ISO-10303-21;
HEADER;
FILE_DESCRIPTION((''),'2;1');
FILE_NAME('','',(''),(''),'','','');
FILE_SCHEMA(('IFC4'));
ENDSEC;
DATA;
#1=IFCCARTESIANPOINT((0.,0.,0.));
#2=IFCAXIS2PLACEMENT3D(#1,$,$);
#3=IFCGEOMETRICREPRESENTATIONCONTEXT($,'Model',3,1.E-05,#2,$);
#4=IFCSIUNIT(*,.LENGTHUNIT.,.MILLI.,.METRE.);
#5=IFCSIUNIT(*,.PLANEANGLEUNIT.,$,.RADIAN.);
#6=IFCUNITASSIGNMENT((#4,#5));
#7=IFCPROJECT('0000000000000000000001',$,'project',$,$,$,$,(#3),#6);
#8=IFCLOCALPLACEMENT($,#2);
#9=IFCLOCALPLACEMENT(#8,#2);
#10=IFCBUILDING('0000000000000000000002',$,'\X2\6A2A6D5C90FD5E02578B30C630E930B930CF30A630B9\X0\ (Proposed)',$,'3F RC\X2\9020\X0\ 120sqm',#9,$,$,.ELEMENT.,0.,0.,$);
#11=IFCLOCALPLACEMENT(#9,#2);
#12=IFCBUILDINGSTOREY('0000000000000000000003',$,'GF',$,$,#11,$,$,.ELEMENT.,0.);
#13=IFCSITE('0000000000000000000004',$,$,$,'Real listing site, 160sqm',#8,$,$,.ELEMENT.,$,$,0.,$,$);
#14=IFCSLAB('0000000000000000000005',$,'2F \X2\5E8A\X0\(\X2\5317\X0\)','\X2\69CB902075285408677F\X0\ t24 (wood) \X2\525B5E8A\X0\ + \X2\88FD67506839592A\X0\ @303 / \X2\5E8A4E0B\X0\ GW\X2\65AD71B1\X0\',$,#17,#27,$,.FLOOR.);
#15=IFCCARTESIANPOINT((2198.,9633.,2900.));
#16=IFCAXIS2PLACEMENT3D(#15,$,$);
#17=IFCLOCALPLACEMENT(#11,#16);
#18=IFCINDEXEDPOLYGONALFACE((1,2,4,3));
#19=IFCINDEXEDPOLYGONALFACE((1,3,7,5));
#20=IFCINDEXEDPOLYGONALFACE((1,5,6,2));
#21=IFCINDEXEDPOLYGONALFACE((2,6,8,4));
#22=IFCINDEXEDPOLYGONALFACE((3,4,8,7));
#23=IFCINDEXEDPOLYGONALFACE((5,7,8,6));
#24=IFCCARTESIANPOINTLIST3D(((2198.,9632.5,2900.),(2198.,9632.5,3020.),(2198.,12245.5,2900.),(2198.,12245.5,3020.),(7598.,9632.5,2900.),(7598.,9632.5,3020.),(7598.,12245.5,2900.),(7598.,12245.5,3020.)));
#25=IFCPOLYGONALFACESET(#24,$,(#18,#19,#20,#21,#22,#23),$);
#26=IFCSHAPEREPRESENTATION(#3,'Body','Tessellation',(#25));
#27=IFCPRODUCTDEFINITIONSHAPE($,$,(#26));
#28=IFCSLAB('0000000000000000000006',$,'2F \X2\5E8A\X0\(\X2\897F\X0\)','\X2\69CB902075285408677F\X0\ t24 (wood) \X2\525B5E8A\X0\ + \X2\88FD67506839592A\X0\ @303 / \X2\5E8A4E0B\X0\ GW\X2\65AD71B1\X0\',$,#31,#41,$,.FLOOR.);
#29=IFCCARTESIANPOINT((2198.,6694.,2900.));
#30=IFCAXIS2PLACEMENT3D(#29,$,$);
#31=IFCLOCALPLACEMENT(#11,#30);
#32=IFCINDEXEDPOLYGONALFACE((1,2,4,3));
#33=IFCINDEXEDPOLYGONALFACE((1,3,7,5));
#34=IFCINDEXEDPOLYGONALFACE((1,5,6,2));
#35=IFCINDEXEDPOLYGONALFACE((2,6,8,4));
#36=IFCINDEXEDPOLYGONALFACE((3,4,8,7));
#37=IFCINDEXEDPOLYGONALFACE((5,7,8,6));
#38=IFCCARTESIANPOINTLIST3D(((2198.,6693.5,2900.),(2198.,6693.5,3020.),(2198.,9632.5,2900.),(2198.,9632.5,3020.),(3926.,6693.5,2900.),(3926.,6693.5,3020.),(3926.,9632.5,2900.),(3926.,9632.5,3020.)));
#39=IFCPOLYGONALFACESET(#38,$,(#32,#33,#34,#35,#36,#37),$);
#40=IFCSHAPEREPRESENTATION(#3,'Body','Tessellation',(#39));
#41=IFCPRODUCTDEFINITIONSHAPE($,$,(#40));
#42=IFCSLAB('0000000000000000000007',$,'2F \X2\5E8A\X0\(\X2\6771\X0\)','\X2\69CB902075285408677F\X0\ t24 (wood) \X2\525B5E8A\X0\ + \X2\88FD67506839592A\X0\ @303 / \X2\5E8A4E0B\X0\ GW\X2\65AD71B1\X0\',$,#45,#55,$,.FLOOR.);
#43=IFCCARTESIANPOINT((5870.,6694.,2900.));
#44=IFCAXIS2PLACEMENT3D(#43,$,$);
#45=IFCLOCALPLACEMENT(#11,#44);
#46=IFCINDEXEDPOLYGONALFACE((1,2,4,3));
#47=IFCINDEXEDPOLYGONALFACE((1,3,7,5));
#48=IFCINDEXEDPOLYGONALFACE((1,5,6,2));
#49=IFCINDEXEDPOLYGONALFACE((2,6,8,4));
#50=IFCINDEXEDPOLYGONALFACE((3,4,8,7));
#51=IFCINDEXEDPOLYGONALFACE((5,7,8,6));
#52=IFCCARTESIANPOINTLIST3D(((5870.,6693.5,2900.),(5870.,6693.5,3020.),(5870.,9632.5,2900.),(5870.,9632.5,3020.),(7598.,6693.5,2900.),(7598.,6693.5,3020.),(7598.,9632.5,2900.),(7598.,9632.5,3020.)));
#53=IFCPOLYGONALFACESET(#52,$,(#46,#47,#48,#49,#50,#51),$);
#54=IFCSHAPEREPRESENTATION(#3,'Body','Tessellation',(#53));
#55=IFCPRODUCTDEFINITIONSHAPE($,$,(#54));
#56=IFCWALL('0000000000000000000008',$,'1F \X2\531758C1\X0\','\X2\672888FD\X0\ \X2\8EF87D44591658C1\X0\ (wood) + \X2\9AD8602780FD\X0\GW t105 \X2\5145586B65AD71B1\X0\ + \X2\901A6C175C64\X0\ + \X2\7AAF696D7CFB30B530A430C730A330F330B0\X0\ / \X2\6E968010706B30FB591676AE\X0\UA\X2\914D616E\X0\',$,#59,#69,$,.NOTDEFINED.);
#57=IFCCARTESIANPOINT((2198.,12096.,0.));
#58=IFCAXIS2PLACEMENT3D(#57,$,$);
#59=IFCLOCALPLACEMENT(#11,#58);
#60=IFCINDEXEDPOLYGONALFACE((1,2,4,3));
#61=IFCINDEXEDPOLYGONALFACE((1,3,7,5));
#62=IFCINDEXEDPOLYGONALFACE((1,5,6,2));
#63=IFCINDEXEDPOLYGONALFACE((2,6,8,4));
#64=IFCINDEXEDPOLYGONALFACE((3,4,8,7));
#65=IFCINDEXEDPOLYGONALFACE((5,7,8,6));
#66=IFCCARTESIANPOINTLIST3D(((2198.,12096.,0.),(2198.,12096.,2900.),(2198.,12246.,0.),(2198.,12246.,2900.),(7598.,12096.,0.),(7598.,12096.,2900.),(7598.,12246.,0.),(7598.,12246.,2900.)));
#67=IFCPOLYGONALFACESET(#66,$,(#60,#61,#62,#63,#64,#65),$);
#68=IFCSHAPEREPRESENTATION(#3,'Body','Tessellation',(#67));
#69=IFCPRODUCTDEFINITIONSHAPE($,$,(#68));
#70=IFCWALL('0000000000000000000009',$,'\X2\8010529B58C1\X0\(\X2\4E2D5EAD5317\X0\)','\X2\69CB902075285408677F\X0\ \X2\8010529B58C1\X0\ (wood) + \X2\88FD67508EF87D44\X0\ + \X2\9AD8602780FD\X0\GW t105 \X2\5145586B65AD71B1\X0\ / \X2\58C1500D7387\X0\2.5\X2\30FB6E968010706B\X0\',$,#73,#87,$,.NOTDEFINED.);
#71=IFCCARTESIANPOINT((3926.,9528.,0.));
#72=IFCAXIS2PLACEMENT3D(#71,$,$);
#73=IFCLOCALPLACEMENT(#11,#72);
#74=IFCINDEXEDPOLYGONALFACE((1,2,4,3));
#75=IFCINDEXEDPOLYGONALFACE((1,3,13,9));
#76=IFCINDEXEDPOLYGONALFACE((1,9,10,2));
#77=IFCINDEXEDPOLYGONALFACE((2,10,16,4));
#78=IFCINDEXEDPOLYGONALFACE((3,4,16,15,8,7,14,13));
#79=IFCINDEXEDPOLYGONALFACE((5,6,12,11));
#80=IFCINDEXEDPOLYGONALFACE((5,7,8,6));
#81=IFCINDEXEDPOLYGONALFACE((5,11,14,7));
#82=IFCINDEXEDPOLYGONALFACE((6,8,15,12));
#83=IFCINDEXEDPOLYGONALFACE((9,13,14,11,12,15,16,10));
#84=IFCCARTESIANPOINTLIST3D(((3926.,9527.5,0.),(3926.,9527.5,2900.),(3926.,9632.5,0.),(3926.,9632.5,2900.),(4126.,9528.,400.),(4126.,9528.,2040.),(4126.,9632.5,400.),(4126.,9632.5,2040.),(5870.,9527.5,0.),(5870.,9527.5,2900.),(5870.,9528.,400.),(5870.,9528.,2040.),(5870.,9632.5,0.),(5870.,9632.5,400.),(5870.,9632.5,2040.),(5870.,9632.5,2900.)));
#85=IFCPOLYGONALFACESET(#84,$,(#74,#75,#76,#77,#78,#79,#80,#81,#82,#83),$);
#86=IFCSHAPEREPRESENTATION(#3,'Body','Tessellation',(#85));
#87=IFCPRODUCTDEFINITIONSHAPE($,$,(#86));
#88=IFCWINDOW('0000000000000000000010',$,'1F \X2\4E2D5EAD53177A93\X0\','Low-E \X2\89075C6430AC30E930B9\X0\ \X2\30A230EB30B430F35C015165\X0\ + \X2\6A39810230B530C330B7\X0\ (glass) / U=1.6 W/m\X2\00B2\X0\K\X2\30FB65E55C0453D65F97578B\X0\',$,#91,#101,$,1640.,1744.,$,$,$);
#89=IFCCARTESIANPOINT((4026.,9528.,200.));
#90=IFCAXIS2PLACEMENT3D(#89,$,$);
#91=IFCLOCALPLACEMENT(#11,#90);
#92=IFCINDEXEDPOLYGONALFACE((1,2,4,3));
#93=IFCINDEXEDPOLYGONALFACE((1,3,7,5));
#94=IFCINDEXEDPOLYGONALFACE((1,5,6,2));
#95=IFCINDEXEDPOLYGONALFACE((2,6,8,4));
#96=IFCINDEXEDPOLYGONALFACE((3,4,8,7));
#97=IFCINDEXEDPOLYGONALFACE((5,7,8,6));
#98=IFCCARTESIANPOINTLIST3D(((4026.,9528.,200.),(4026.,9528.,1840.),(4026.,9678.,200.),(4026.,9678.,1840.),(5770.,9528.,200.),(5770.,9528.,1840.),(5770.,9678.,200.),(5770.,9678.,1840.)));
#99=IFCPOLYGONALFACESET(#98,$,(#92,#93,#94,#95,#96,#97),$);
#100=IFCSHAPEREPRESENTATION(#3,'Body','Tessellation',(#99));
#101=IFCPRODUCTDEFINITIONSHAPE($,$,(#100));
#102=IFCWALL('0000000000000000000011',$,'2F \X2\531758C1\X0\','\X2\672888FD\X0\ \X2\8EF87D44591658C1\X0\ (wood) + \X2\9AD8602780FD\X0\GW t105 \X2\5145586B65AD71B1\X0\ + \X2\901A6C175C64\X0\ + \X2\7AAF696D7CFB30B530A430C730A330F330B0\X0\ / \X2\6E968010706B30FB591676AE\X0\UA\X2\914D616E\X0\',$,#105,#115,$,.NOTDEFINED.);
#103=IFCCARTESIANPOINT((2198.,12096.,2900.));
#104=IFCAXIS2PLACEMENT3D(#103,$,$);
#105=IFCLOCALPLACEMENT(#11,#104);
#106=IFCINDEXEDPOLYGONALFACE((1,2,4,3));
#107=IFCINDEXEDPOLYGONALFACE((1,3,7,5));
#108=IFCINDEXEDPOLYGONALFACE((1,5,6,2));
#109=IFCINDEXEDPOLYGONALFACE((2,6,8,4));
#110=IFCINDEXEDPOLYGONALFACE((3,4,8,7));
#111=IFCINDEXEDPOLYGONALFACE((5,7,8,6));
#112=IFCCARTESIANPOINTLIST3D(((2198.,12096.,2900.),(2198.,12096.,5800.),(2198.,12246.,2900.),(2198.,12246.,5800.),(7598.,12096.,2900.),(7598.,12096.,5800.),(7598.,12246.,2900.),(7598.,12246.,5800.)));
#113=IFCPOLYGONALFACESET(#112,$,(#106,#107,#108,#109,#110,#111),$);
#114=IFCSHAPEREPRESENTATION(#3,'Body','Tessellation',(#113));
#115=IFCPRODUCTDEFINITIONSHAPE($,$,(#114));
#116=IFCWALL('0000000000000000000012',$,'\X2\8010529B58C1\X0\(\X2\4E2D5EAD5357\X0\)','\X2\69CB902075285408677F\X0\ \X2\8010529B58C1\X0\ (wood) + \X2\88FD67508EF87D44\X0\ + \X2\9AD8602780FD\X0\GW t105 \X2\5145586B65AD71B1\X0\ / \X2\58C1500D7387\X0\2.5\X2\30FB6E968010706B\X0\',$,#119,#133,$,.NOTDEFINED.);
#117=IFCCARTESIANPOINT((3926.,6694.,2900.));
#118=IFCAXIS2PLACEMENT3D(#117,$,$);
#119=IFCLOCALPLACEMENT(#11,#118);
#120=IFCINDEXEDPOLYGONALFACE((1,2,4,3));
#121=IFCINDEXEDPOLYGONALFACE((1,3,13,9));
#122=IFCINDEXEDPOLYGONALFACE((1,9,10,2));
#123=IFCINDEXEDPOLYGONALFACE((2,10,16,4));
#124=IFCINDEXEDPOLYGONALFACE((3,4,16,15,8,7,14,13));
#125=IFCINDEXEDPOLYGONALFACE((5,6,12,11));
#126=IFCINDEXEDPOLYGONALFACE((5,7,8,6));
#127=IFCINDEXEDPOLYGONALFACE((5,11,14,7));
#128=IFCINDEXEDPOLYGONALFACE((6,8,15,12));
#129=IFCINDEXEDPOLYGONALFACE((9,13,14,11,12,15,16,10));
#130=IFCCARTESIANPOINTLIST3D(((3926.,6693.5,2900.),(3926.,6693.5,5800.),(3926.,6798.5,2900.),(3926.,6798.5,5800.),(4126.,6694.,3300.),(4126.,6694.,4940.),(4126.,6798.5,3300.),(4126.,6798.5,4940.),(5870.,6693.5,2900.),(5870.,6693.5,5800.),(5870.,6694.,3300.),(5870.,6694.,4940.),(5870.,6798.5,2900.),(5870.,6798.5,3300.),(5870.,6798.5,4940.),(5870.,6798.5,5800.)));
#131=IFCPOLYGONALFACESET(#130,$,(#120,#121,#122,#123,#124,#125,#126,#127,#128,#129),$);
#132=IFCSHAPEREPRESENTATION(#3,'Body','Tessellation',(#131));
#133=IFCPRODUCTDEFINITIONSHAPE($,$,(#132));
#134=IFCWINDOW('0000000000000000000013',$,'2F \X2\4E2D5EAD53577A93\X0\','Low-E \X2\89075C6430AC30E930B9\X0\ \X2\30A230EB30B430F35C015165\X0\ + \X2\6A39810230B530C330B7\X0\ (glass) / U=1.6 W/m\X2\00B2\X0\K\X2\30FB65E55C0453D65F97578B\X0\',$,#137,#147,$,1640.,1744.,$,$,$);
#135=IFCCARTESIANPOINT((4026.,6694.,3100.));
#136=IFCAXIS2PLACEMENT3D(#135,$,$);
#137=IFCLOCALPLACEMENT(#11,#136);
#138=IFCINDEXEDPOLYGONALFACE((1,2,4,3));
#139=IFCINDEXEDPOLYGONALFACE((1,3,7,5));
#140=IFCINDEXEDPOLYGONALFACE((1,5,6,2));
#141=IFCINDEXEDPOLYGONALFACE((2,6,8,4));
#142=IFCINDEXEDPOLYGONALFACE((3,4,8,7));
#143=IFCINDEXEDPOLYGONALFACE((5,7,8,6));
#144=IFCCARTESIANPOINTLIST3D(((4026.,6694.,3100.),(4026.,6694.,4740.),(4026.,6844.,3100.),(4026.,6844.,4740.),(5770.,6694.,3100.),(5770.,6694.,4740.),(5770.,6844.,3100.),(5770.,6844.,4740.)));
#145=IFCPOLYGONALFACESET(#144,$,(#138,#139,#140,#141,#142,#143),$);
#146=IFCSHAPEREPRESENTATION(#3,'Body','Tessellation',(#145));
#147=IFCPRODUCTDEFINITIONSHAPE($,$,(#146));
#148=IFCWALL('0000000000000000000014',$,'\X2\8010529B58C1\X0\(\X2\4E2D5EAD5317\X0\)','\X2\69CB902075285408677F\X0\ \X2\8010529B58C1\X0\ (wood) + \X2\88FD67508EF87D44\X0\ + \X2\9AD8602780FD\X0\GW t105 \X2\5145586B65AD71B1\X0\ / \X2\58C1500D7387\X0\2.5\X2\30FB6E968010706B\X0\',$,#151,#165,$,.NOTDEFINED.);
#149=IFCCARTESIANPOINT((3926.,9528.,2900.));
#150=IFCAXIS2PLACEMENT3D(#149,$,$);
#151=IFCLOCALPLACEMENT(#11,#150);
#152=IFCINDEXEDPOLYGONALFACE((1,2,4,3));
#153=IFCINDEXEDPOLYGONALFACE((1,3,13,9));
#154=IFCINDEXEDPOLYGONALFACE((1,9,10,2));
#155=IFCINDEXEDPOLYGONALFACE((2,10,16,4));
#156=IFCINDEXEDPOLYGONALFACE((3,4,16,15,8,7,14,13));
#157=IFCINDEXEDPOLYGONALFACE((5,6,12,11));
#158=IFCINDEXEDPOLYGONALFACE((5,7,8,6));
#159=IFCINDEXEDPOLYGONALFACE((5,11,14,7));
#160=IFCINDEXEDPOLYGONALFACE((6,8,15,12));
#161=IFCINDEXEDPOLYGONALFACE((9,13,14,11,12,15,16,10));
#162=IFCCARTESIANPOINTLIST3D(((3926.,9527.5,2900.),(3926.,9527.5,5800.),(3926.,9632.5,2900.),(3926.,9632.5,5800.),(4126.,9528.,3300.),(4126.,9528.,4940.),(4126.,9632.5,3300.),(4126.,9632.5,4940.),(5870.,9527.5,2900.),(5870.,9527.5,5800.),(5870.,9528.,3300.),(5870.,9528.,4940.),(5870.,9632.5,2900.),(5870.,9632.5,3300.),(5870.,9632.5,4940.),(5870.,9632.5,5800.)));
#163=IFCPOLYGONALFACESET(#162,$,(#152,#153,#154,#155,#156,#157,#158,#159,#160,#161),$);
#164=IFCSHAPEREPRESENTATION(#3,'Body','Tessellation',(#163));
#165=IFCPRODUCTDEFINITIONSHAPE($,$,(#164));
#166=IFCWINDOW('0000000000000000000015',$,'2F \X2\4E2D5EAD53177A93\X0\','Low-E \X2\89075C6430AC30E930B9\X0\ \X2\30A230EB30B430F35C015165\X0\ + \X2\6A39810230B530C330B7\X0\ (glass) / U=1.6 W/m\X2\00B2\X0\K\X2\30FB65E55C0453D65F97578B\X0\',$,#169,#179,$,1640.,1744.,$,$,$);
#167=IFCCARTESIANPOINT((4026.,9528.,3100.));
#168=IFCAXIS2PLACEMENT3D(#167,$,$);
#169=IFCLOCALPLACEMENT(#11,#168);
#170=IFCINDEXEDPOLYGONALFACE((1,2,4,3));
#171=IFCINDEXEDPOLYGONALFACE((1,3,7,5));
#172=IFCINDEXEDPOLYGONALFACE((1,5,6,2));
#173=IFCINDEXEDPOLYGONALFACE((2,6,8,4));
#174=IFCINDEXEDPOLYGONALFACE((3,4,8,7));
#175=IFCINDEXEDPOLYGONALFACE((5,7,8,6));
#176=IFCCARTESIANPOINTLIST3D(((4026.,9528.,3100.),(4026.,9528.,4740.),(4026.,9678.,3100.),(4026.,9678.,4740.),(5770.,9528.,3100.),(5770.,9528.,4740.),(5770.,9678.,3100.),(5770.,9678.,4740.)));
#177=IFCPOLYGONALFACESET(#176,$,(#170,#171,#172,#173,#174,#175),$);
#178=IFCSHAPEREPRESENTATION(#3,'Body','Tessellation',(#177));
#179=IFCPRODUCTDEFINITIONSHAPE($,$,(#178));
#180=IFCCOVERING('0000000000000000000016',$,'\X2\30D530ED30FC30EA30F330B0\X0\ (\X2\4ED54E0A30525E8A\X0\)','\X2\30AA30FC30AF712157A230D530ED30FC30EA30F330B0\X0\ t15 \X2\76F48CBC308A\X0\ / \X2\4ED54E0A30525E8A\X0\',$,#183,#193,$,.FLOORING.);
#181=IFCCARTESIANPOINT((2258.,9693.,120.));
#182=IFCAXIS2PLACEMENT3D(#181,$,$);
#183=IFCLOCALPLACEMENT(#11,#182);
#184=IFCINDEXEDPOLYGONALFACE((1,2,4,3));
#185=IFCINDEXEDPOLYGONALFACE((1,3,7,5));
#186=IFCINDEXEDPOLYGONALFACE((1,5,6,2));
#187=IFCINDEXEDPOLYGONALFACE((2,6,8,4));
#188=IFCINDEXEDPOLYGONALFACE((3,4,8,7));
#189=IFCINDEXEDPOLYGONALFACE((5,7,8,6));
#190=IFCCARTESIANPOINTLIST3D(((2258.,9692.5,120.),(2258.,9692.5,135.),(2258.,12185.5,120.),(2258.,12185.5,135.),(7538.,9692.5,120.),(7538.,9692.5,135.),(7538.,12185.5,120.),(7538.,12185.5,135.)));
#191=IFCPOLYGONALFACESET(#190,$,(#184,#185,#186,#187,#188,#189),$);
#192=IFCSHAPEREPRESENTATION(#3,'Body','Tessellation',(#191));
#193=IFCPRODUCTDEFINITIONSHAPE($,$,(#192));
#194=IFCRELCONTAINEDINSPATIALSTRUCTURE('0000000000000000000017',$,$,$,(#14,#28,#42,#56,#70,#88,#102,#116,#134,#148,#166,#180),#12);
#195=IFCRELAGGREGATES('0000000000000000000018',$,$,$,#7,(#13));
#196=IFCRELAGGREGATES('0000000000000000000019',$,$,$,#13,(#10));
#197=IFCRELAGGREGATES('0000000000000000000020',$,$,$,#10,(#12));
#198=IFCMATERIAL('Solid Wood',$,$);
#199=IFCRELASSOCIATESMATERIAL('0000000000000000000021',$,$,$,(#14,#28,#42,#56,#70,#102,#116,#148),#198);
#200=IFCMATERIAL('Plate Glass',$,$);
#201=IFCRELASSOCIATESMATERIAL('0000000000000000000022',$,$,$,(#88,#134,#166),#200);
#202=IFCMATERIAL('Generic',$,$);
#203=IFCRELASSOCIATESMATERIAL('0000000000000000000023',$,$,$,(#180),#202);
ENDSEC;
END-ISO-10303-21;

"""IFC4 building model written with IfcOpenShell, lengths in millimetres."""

from ifc_helpers import new_model, si_unit, frame, frame_2d, origin, place, context, project, spatial, rectangle, extrude, material, element, fill, save


model = new_model("IFC4")

# Units and contexts
model_context = context("Model", 3, precision=1e-05, world=origin())
ifc_project = project(units=[si_unit("LENGTHUNIT", "METRE", prefix="MILLI"), si_unit("PLANEANGLEUNIT", "RADIAN")], contexts=[model_context])

# Site, building, storey
site_placement = place(None, origin())
site = spatial("IfcSite", under=ifc_project, at=site_placement, ObjectType="Real listing site, 160sqm", CompositionType="ELEMENT", RefElevation=0.0)
building_placement = place(site_placement, origin())
building = spatial("IfcBuilding", under=site, at=building_placement, Name="横浜都市型テラスハウス (Proposed)", ObjectType="3F RC造 120sqm", CompositionType="ELEMENT", ElevationOfRefHeight=0.0, ElevationOfTerrain=0.0)
storey_placement = place(building_placement, origin())
storey = spatial("IfcBuildingStorey", under=building, at=storey_placement, Name="GF", CompositionType="ELEMENT", Elevation=0.0)

# Slabs
ifc_material_1 = material(Name="Solid Wood")
slab_1_placement = place(storey_placement, frame((2198.0, 9633.0, 2900.0)))
element("IfcSlab", 1, at=slab_1_placement, inside=storey, material=ifc_material_1, Name="2F 床(北)", Description="構造用合板 t24 (wood) 剛床 + 製材根太 @303 / 床下 GW断熱", PredefinedType="FLOOR", context=model_context, shape_type="SweptSolid", body=[
    extrude(rectangle(XDim=5400.0, YDim=2613.0, at=frame_2d((2700.0, 1306.0))), frame((2198.0, 9633.0, 2900.0)), (0.0, 0.0, 1.0), 120.0),
])
slab_2_placement = place(storey_placement, frame((2198.0, 6694.0, 2900.0)))
element("IfcSlab", 2, at=slab_2_placement, inside=storey, material=ifc_material_1, Name="2F 床(西)", Description="構造用合板 t24 (wood) 剛床 + 製材根太 @303 / 床下 GW断熱", PredefinedType="FLOOR", context=model_context, shape_type="SweptSolid", body=[
    extrude(rectangle(XDim=1728.0, YDim=2939.0, at=frame_2d((864.0, 1469.0))), frame((2198.0, 6694.0, 2900.0)), (0.0, 0.0, 1.0), 120.0),
])
slab_3_placement = place(storey_placement, frame((5870.0, 6694.0, 2900.0)))
element("IfcSlab", 3, at=slab_3_placement, inside=storey, material=ifc_material_1, Name="2F 床(東)", Description="構造用合板 t24 (wood) 剛床 + 製材根太 @303 / 床下 GW断熱", PredefinedType="FLOOR", context=model_context, shape_type="SweptSolid", body=[
    extrude(rectangle(XDim=1728.0, YDim=2939.0, at=frame_2d((864.0, 1469.0))), frame((5870.0, 6694.0, 2900.0)), (0.0, 0.0, 1.0), 120.0),
])

# Wall
wall_1_placement = place(storey_placement, frame((2198.0, 12096.0, 0.0)))
element("IfcWall", 4, at=wall_1_placement, inside=storey, material=ifc_material_1, Name="1F 北壁", Description="木製 軸組外壁 (wood) + 高性能GW t105 充填断熱 + 通気層 + 窯業系サイディング / 準耐火・外皮UA配慮", PredefinedType="NOTDEFINED", context=model_context, shape_type="SweptSolid", body=[
    extrude(rectangle(XDim=5400.0, YDim=150.0, at=frame_2d((2700.0, 75.0))), frame((2198.0, 12096.0, 0.0)), (0.0, 0.0, 1.0), 2900.0),
])

# Wall, opening, window
wall_2_placement = place(storey_placement, frame((3926.0, 9528.0, 0.0)))
wall_2 = element("IfcWall", 5, at=wall_2_placement, inside=storey, material=ifc_material_1, Name="耐力壁(中庭北)", Description="構造用合板 耐力壁 (wood) + 製材軸組 + 高性能GW t105 充填断熱 / 壁倍率2.5・準耐火", PredefinedType="NOTDEFINED", context=model_context, shape_type="SweptSolid", body=[
    extrude(rectangle(XDim=1944.0, YDim=105.0, at=frame_2d((972.0, 52.0))), frame((3926.0, 9528.0, 0.0)), (0.0, 0.0, 1.0), 2900.0),
])
opening_1_placement = place(storey_placement, frame((4026.0, 9528.0, 200.0)))
opening_1 = element("IfcOpeningElement", 6, at=opening_1_placement, cuts=wall_2, PredefinedType="NOTDEFINED", context=model_context, shape_type="SweptSolid", body=[
    extrude(rectangle(XDim=1744.0, YDim=150.0, at=frame_2d((872.0, 75.0))), frame((4026.0, 9528.0, 200.0)), (0.0, 0.0, 1.0), 1640.0),
])
ifc_material_2 = material(Name="Plate Glass")
window_1_placement = place(storey_placement, frame((4026.0, 9528.0, 200.0)))
window_1 = element("IfcWindow", 7, at=window_1_placement, inside=storey, material=ifc_material_2, Name="1F 中庭北窓", Description="Low-E 複層ガラス アルゴン封入 + 樹脂サッシ (glass) / U=1.6 W/m²K・日射取得型", OverallHeight=1640.0, OverallWidth=1744.0, context=model_context, shape_type="SweptSolid", body=[
    extrude(rectangle(XDim=1744.0, YDim=150.0, at=frame_2d((872.0, 75.0))), frame((4026.0, 9528.0, 200.0)), (0.0, 0.0, 1.0), 1640.0),
])
fill(opening_1, window_1)

# Wall
wall_3_placement = place(storey_placement, frame((2198.0, 12096.0, 2900.0)))
element("IfcWall", 8, at=wall_3_placement, inside=storey, material=ifc_material_1, Name="2F 北壁", Description="木製 軸組外壁 (wood) + 高性能GW t105 充填断熱 + 通気層 + 窯業系サイディング / 準耐火・外皮UA配慮", PredefinedType="NOTDEFINED", context=model_context, shape_type="SweptSolid", body=[
    extrude(rectangle(XDim=5400.0, YDim=150.0, at=frame_2d((2700.0, 75.0))), frame((2198.0, 12096.0, 2900.0)), (0.0, 0.0, 1.0), 2900.0),
])

# Walls, openings, windows
wall_4_placement = place(storey_placement, frame((3926.0, 6694.0, 2900.0)))
wall_4 = element("IfcWall", 9, at=wall_4_placement, inside=storey, material=ifc_material_1, Name="耐力壁(中庭南)", Description="構造用合板 耐力壁 (wood) + 製材軸組 + 高性能GW t105 充填断熱 / 壁倍率2.5・準耐火", PredefinedType="NOTDEFINED", context=model_context, shape_type="SweptSolid", body=[
    extrude(rectangle(XDim=1944.0, YDim=105.0, at=frame_2d((972.0, 52.0))), frame((3926.0, 6694.0, 2900.0)), (0.0, 0.0, 1.0), 2900.0),
])
opening_2_placement = place(storey_placement, frame((4026.0, 6694.0, 3100.0)))
opening_2 = element("IfcOpeningElement", 10, at=opening_2_placement, cuts=wall_4, PredefinedType="NOTDEFINED", context=model_context, shape_type="SweptSolid", body=[
    extrude(rectangle(XDim=1744.0, YDim=150.0, at=frame_2d((872.0, 75.0))), frame((4026.0, 6694.0, 3100.0)), (0.0, 0.0, 1.0), 1640.0),
])
window_2_placement = place(storey_placement, frame((4026.0, 6694.0, 3100.0)))
window_2 = element("IfcWindow", 11, at=window_2_placement, inside=storey, material=ifc_material_2, Name="2F 中庭南窓", Description="Low-E 複層ガラス アルゴン封入 + 樹脂サッシ (glass) / U=1.6 W/m²K・日射取得型", OverallHeight=1640.0, OverallWidth=1744.0, context=model_context, shape_type="SweptSolid", body=[
    extrude(rectangle(XDim=1744.0, YDim=150.0, at=frame_2d((872.0, 75.0))), frame((4026.0, 6694.0, 3100.0)), (0.0, 0.0, 1.0), 1640.0),
])
fill(opening_2, window_2)
wall_5_placement = place(storey_placement, frame((3926.0, 9528.0, 2900.0)))
wall_5 = element("IfcWall", 12, at=wall_5_placement, inside=storey, material=ifc_material_1, Name="耐力壁(中庭北)", Description="構造用合板 耐力壁 (wood) + 製材軸組 + 高性能GW t105 充填断熱 / 壁倍率2.5・準耐火", PredefinedType="NOTDEFINED", context=model_context, shape_type="SweptSolid", body=[
    extrude(rectangle(XDim=1944.0, YDim=105.0, at=frame_2d((972.0, 52.0))), frame((3926.0, 9528.0, 2900.0)), (0.0, 0.0, 1.0), 2900.0),
])
opening_3_placement = place(storey_placement, frame((4026.0, 9528.0, 3100.0)))
opening_3 = element("IfcOpeningElement", 13, at=opening_3_placement, cuts=wall_5, PredefinedType="NOTDEFINED", context=model_context, shape_type="SweptSolid", body=[
    extrude(rectangle(XDim=1744.0, YDim=150.0, at=frame_2d((872.0, 75.0))), frame((4026.0, 9528.0, 3100.0)), (0.0, 0.0, 1.0), 1640.0),
])
window_3_placement = place(storey_placement, frame((4026.0, 9528.0, 3100.0)))
window_3 = element("IfcWindow", 14, at=window_3_placement, inside=storey, material=ifc_material_2, Name="2F 中庭北窓", Description="Low-E 複層ガラス アルゴン封入 + 樹脂サッシ (glass) / U=1.6 W/m²K・日射取得型", OverallHeight=1640.0, OverallWidth=1744.0, context=model_context, shape_type="SweptSolid", body=[
    extrude(rectangle(XDim=1744.0, YDim=150.0, at=frame_2d((872.0, 75.0))), frame((4026.0, 9528.0, 3100.0)), (0.0, 0.0, 1.0), 1640.0),
])
fill(opening_3, window_3)

# Covering
ifc_material_3 = material(Name="Generic")
covering_1_placement = place(storey_placement, frame((2258.0, 9693.0, 120.0)))
element("IfcCovering", 15, at=covering_1_placement, inside=storey, material=ifc_material_3, Name="フローリング (仕上げ床)", Description="オーク無垢フローリング t15 直貼り / 仕上げ床", PredefinedType="FLOORING", context=model_context, shape_type="SweptSolid", body=[
    extrude(rectangle(XDim=5280.0, YDim=2493.0, at=frame_2d((2640.0, 1246.0))), frame((2258.0, 9693.0, 120.0)), (0.0, 0.0, 1.0), 15.0),
])

save(model, "model.ifc")
